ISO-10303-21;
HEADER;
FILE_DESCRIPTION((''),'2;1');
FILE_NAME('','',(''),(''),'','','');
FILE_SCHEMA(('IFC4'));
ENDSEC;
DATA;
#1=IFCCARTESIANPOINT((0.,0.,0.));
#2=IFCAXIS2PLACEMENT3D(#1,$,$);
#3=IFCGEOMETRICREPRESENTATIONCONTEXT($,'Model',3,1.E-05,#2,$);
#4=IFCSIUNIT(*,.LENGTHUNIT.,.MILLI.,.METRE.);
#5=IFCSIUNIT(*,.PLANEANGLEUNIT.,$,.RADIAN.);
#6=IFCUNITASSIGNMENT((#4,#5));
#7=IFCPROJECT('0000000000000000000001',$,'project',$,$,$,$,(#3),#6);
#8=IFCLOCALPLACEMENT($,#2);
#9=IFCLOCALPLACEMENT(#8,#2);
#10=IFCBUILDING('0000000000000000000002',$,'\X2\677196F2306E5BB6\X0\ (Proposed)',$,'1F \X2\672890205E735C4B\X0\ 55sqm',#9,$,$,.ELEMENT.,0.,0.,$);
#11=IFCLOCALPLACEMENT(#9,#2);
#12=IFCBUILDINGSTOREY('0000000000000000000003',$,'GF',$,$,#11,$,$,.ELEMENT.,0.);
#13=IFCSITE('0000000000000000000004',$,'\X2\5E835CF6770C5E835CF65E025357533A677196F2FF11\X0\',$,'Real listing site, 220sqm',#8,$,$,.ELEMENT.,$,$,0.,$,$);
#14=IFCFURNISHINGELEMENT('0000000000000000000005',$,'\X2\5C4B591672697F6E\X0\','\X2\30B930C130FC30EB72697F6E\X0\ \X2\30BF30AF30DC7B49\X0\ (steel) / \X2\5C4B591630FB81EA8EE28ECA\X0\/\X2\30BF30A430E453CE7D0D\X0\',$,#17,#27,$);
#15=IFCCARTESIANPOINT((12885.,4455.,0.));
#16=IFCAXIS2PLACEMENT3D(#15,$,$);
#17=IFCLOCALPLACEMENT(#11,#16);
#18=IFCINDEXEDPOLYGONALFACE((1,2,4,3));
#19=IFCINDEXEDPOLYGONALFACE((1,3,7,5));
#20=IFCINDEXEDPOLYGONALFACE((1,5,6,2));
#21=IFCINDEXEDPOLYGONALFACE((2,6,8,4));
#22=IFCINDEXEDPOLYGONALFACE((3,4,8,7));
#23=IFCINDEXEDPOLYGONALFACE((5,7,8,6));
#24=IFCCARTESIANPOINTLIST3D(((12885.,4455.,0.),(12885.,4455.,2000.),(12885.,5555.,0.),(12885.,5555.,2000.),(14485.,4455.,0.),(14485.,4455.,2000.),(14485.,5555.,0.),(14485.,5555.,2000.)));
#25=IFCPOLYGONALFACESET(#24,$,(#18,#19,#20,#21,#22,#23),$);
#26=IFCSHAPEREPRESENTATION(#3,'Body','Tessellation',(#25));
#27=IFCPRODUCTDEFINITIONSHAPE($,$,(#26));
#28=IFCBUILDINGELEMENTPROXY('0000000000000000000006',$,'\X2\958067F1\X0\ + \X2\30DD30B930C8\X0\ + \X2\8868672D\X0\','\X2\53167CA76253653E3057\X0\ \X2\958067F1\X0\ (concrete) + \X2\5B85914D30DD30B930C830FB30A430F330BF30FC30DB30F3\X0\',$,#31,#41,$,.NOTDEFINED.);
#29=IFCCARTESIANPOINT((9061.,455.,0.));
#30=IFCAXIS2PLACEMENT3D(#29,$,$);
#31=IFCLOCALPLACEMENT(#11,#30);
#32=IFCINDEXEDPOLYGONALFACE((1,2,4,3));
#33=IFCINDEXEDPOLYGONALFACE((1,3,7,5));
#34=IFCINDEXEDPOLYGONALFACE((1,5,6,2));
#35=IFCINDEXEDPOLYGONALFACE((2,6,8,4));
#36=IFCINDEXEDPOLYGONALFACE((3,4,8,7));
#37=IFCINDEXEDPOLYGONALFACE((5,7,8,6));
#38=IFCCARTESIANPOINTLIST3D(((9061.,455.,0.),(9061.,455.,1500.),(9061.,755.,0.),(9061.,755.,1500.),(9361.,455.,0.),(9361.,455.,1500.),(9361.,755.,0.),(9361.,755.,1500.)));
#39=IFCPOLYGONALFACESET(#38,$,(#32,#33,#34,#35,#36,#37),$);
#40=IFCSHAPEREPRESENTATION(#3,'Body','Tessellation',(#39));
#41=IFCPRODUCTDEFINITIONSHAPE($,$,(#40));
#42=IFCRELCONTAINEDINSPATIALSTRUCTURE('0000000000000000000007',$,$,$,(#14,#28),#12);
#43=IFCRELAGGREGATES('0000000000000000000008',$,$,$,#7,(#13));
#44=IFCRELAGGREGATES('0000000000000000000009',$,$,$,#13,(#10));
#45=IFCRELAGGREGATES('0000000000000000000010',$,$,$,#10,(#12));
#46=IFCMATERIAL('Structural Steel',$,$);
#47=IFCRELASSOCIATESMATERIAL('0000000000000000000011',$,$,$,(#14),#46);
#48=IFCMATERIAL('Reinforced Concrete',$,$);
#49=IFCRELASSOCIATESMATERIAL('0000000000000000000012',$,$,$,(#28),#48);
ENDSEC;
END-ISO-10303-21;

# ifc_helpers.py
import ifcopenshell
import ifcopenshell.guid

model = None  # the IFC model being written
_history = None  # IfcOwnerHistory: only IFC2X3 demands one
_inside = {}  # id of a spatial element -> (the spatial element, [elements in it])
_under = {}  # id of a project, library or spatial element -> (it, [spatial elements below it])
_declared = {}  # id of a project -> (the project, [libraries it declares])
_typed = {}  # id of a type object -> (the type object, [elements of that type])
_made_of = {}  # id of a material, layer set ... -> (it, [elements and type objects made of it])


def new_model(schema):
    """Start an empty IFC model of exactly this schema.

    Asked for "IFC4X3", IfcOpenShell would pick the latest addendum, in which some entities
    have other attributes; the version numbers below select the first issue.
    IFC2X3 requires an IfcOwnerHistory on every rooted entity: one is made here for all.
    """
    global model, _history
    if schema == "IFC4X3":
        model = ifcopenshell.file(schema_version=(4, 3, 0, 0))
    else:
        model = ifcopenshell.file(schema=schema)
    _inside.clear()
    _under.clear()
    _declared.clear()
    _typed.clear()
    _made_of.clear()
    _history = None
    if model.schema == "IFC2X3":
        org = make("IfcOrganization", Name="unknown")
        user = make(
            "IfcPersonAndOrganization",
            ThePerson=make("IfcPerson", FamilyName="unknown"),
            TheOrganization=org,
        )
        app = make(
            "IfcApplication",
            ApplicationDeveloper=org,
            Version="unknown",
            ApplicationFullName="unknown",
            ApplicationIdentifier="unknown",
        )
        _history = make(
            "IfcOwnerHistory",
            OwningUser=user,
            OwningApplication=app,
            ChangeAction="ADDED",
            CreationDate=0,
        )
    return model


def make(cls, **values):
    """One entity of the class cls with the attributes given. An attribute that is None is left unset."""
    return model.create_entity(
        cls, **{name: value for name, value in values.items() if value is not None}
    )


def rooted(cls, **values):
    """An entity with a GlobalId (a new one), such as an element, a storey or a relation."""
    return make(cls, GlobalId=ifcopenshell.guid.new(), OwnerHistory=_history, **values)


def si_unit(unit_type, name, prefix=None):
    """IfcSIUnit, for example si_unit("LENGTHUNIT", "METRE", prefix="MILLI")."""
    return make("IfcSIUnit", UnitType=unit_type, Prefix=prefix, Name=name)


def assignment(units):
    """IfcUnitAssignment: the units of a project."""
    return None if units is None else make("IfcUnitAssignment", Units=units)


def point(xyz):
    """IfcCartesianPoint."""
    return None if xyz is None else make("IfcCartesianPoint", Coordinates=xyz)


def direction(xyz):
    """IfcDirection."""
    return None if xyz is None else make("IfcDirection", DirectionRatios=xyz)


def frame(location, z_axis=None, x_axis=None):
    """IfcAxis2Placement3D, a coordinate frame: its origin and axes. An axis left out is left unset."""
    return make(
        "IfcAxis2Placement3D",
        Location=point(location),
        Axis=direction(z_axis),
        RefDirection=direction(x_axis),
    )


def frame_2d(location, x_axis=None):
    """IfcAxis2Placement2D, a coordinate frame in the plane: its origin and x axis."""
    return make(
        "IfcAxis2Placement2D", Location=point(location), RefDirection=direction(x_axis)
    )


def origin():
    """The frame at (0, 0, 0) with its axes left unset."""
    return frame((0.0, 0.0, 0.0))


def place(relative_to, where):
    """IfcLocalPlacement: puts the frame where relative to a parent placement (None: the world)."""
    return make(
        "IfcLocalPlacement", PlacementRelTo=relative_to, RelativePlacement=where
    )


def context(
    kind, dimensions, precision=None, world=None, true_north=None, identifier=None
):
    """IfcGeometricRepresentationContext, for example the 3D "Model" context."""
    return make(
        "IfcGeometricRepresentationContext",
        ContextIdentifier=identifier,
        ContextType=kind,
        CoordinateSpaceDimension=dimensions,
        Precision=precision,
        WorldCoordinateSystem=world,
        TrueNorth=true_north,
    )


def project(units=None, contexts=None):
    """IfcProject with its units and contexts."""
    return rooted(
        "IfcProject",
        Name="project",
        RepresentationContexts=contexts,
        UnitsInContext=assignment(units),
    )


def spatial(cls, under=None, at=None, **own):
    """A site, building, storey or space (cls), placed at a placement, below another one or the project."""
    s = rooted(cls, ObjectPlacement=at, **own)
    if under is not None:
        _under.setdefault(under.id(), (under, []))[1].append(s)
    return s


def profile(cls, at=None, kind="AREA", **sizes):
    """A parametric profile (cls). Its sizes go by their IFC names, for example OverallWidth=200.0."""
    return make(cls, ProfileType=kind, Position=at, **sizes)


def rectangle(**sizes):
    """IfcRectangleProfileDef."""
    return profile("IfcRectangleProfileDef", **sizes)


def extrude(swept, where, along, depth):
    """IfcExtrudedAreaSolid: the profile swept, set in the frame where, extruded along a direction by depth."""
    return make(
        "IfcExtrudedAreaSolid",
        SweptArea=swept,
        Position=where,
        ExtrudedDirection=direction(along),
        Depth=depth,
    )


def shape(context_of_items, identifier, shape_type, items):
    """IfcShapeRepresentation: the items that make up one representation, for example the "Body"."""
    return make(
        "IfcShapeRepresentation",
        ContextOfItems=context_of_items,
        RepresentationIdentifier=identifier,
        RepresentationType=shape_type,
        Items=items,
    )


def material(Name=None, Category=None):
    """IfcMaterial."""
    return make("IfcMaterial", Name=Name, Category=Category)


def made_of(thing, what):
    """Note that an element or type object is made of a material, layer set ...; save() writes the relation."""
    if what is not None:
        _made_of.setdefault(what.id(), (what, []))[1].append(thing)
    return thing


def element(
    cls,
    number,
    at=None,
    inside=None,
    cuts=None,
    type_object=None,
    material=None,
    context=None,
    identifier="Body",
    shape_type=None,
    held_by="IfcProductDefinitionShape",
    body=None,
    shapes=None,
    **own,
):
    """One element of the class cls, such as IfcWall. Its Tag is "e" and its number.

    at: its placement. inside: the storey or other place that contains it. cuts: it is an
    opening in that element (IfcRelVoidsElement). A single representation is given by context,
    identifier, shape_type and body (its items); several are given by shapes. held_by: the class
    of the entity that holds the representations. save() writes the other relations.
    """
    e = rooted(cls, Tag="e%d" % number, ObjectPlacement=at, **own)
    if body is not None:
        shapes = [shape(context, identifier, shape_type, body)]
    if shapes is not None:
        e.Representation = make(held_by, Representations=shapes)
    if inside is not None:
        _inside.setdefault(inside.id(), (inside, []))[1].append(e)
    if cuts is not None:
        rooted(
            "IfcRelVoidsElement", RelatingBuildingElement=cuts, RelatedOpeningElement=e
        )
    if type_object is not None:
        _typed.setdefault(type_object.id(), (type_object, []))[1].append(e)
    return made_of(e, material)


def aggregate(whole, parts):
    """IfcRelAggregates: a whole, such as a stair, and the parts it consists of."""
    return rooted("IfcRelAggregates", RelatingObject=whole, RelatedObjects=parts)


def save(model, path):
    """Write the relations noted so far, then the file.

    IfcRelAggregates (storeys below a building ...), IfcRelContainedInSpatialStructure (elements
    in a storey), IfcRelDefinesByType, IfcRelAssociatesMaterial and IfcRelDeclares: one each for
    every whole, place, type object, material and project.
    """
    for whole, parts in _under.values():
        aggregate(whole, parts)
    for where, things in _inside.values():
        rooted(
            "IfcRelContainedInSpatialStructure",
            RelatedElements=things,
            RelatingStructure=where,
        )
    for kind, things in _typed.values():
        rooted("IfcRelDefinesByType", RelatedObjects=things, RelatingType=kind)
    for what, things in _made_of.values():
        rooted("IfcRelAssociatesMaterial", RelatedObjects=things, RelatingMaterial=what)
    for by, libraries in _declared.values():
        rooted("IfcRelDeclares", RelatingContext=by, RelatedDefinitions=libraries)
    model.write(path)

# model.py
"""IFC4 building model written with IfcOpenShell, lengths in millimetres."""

from ifc_helpers import new_model, si_unit, frame, frame_2d, origin, place, context, project, spatial, rectangle, extrude, material, element, save


model = new_model("IFC4")

# Units and contexts
model_context = context("Model", 3, precision=1e-05, world=origin())
ifc_project = project(units=[si_unit("LENGTHUNIT", "METRE", prefix="MILLI"), si_unit("PLANEANGLEUNIT", "RADIAN")], contexts=[model_context])

# Site, building, storey
site_placement = place(None, origin())
site = spatial("IfcSite", under=ifc_project, at=site_placement, Name="広島県広島市南区東雲１", ObjectType="Real listing site, 220sqm", CompositionType="ELEMENT", RefElevation=0.0)
building_placement = place(site_placement, origin())
building = spatial("IfcBuilding", under=site, at=building_placement, Name="東雲の家 (Proposed)", ObjectType="1F 木造平屋 55sqm", CompositionType="ELEMENT", ElevationOfRefHeight=0.0, ElevationOfTerrain=0.0)
storey_placement = place(building_placement, origin())
storey = spatial("IfcBuildingStorey", under=building, at=storey_placement, Name="GF", CompositionType="ELEMENT", Elevation=0.0)

# Shared definitions
ifc_material_1 = material(Name="Reinforced Concrete")

# Shared definitions
ifc_material_2 = material(Name="Structural Steel")

# Furnishing element
furnishing_1_placement = place(storey_placement, frame((12885.0, 4455.0, 0.0)))
element("IfcFurnishingElement", 1, at=furnishing_1_placement, inside=storey, material=ifc_material_2, Name="屋外物置", Description="スチール物置 タクボ等 (steel) / 屋外・自転車/タイヤ収納", context=model_context, shape_type="SweptSolid", body=[
    extrude(rectangle(XDim=1600.0, YDim=1100.0, at=frame_2d((800.0, 550.0))), frame((12885.0, 4455.0, 0.0)), (0.0, 0.0, 1.0), 2000.0),
])

# Building element proxy
proxy_placement = place(storey_placement, frame((9061.0, 455.0, 0.0)))
element("IfcBuildingElementProxy", 2, at=proxy_placement, inside=storey, material=ifc_material_1, Name="門柱 + ポスト + 表札", Description="化粧打放し 門柱 (concrete) + 宅配ポスト・インターホン", PredefinedType="NOTDEFINED", context=model_context, shape_type="SweptSolid", body=[
    extrude(rectangle(XDim=300.0, YDim=300.0, at=frame_2d((150.0, 150.0))), frame((9061.0, 455.0, 0.0)), (0.0, 0.0, 1.0), 1500.0),
])

save(model, "model.ifc")
